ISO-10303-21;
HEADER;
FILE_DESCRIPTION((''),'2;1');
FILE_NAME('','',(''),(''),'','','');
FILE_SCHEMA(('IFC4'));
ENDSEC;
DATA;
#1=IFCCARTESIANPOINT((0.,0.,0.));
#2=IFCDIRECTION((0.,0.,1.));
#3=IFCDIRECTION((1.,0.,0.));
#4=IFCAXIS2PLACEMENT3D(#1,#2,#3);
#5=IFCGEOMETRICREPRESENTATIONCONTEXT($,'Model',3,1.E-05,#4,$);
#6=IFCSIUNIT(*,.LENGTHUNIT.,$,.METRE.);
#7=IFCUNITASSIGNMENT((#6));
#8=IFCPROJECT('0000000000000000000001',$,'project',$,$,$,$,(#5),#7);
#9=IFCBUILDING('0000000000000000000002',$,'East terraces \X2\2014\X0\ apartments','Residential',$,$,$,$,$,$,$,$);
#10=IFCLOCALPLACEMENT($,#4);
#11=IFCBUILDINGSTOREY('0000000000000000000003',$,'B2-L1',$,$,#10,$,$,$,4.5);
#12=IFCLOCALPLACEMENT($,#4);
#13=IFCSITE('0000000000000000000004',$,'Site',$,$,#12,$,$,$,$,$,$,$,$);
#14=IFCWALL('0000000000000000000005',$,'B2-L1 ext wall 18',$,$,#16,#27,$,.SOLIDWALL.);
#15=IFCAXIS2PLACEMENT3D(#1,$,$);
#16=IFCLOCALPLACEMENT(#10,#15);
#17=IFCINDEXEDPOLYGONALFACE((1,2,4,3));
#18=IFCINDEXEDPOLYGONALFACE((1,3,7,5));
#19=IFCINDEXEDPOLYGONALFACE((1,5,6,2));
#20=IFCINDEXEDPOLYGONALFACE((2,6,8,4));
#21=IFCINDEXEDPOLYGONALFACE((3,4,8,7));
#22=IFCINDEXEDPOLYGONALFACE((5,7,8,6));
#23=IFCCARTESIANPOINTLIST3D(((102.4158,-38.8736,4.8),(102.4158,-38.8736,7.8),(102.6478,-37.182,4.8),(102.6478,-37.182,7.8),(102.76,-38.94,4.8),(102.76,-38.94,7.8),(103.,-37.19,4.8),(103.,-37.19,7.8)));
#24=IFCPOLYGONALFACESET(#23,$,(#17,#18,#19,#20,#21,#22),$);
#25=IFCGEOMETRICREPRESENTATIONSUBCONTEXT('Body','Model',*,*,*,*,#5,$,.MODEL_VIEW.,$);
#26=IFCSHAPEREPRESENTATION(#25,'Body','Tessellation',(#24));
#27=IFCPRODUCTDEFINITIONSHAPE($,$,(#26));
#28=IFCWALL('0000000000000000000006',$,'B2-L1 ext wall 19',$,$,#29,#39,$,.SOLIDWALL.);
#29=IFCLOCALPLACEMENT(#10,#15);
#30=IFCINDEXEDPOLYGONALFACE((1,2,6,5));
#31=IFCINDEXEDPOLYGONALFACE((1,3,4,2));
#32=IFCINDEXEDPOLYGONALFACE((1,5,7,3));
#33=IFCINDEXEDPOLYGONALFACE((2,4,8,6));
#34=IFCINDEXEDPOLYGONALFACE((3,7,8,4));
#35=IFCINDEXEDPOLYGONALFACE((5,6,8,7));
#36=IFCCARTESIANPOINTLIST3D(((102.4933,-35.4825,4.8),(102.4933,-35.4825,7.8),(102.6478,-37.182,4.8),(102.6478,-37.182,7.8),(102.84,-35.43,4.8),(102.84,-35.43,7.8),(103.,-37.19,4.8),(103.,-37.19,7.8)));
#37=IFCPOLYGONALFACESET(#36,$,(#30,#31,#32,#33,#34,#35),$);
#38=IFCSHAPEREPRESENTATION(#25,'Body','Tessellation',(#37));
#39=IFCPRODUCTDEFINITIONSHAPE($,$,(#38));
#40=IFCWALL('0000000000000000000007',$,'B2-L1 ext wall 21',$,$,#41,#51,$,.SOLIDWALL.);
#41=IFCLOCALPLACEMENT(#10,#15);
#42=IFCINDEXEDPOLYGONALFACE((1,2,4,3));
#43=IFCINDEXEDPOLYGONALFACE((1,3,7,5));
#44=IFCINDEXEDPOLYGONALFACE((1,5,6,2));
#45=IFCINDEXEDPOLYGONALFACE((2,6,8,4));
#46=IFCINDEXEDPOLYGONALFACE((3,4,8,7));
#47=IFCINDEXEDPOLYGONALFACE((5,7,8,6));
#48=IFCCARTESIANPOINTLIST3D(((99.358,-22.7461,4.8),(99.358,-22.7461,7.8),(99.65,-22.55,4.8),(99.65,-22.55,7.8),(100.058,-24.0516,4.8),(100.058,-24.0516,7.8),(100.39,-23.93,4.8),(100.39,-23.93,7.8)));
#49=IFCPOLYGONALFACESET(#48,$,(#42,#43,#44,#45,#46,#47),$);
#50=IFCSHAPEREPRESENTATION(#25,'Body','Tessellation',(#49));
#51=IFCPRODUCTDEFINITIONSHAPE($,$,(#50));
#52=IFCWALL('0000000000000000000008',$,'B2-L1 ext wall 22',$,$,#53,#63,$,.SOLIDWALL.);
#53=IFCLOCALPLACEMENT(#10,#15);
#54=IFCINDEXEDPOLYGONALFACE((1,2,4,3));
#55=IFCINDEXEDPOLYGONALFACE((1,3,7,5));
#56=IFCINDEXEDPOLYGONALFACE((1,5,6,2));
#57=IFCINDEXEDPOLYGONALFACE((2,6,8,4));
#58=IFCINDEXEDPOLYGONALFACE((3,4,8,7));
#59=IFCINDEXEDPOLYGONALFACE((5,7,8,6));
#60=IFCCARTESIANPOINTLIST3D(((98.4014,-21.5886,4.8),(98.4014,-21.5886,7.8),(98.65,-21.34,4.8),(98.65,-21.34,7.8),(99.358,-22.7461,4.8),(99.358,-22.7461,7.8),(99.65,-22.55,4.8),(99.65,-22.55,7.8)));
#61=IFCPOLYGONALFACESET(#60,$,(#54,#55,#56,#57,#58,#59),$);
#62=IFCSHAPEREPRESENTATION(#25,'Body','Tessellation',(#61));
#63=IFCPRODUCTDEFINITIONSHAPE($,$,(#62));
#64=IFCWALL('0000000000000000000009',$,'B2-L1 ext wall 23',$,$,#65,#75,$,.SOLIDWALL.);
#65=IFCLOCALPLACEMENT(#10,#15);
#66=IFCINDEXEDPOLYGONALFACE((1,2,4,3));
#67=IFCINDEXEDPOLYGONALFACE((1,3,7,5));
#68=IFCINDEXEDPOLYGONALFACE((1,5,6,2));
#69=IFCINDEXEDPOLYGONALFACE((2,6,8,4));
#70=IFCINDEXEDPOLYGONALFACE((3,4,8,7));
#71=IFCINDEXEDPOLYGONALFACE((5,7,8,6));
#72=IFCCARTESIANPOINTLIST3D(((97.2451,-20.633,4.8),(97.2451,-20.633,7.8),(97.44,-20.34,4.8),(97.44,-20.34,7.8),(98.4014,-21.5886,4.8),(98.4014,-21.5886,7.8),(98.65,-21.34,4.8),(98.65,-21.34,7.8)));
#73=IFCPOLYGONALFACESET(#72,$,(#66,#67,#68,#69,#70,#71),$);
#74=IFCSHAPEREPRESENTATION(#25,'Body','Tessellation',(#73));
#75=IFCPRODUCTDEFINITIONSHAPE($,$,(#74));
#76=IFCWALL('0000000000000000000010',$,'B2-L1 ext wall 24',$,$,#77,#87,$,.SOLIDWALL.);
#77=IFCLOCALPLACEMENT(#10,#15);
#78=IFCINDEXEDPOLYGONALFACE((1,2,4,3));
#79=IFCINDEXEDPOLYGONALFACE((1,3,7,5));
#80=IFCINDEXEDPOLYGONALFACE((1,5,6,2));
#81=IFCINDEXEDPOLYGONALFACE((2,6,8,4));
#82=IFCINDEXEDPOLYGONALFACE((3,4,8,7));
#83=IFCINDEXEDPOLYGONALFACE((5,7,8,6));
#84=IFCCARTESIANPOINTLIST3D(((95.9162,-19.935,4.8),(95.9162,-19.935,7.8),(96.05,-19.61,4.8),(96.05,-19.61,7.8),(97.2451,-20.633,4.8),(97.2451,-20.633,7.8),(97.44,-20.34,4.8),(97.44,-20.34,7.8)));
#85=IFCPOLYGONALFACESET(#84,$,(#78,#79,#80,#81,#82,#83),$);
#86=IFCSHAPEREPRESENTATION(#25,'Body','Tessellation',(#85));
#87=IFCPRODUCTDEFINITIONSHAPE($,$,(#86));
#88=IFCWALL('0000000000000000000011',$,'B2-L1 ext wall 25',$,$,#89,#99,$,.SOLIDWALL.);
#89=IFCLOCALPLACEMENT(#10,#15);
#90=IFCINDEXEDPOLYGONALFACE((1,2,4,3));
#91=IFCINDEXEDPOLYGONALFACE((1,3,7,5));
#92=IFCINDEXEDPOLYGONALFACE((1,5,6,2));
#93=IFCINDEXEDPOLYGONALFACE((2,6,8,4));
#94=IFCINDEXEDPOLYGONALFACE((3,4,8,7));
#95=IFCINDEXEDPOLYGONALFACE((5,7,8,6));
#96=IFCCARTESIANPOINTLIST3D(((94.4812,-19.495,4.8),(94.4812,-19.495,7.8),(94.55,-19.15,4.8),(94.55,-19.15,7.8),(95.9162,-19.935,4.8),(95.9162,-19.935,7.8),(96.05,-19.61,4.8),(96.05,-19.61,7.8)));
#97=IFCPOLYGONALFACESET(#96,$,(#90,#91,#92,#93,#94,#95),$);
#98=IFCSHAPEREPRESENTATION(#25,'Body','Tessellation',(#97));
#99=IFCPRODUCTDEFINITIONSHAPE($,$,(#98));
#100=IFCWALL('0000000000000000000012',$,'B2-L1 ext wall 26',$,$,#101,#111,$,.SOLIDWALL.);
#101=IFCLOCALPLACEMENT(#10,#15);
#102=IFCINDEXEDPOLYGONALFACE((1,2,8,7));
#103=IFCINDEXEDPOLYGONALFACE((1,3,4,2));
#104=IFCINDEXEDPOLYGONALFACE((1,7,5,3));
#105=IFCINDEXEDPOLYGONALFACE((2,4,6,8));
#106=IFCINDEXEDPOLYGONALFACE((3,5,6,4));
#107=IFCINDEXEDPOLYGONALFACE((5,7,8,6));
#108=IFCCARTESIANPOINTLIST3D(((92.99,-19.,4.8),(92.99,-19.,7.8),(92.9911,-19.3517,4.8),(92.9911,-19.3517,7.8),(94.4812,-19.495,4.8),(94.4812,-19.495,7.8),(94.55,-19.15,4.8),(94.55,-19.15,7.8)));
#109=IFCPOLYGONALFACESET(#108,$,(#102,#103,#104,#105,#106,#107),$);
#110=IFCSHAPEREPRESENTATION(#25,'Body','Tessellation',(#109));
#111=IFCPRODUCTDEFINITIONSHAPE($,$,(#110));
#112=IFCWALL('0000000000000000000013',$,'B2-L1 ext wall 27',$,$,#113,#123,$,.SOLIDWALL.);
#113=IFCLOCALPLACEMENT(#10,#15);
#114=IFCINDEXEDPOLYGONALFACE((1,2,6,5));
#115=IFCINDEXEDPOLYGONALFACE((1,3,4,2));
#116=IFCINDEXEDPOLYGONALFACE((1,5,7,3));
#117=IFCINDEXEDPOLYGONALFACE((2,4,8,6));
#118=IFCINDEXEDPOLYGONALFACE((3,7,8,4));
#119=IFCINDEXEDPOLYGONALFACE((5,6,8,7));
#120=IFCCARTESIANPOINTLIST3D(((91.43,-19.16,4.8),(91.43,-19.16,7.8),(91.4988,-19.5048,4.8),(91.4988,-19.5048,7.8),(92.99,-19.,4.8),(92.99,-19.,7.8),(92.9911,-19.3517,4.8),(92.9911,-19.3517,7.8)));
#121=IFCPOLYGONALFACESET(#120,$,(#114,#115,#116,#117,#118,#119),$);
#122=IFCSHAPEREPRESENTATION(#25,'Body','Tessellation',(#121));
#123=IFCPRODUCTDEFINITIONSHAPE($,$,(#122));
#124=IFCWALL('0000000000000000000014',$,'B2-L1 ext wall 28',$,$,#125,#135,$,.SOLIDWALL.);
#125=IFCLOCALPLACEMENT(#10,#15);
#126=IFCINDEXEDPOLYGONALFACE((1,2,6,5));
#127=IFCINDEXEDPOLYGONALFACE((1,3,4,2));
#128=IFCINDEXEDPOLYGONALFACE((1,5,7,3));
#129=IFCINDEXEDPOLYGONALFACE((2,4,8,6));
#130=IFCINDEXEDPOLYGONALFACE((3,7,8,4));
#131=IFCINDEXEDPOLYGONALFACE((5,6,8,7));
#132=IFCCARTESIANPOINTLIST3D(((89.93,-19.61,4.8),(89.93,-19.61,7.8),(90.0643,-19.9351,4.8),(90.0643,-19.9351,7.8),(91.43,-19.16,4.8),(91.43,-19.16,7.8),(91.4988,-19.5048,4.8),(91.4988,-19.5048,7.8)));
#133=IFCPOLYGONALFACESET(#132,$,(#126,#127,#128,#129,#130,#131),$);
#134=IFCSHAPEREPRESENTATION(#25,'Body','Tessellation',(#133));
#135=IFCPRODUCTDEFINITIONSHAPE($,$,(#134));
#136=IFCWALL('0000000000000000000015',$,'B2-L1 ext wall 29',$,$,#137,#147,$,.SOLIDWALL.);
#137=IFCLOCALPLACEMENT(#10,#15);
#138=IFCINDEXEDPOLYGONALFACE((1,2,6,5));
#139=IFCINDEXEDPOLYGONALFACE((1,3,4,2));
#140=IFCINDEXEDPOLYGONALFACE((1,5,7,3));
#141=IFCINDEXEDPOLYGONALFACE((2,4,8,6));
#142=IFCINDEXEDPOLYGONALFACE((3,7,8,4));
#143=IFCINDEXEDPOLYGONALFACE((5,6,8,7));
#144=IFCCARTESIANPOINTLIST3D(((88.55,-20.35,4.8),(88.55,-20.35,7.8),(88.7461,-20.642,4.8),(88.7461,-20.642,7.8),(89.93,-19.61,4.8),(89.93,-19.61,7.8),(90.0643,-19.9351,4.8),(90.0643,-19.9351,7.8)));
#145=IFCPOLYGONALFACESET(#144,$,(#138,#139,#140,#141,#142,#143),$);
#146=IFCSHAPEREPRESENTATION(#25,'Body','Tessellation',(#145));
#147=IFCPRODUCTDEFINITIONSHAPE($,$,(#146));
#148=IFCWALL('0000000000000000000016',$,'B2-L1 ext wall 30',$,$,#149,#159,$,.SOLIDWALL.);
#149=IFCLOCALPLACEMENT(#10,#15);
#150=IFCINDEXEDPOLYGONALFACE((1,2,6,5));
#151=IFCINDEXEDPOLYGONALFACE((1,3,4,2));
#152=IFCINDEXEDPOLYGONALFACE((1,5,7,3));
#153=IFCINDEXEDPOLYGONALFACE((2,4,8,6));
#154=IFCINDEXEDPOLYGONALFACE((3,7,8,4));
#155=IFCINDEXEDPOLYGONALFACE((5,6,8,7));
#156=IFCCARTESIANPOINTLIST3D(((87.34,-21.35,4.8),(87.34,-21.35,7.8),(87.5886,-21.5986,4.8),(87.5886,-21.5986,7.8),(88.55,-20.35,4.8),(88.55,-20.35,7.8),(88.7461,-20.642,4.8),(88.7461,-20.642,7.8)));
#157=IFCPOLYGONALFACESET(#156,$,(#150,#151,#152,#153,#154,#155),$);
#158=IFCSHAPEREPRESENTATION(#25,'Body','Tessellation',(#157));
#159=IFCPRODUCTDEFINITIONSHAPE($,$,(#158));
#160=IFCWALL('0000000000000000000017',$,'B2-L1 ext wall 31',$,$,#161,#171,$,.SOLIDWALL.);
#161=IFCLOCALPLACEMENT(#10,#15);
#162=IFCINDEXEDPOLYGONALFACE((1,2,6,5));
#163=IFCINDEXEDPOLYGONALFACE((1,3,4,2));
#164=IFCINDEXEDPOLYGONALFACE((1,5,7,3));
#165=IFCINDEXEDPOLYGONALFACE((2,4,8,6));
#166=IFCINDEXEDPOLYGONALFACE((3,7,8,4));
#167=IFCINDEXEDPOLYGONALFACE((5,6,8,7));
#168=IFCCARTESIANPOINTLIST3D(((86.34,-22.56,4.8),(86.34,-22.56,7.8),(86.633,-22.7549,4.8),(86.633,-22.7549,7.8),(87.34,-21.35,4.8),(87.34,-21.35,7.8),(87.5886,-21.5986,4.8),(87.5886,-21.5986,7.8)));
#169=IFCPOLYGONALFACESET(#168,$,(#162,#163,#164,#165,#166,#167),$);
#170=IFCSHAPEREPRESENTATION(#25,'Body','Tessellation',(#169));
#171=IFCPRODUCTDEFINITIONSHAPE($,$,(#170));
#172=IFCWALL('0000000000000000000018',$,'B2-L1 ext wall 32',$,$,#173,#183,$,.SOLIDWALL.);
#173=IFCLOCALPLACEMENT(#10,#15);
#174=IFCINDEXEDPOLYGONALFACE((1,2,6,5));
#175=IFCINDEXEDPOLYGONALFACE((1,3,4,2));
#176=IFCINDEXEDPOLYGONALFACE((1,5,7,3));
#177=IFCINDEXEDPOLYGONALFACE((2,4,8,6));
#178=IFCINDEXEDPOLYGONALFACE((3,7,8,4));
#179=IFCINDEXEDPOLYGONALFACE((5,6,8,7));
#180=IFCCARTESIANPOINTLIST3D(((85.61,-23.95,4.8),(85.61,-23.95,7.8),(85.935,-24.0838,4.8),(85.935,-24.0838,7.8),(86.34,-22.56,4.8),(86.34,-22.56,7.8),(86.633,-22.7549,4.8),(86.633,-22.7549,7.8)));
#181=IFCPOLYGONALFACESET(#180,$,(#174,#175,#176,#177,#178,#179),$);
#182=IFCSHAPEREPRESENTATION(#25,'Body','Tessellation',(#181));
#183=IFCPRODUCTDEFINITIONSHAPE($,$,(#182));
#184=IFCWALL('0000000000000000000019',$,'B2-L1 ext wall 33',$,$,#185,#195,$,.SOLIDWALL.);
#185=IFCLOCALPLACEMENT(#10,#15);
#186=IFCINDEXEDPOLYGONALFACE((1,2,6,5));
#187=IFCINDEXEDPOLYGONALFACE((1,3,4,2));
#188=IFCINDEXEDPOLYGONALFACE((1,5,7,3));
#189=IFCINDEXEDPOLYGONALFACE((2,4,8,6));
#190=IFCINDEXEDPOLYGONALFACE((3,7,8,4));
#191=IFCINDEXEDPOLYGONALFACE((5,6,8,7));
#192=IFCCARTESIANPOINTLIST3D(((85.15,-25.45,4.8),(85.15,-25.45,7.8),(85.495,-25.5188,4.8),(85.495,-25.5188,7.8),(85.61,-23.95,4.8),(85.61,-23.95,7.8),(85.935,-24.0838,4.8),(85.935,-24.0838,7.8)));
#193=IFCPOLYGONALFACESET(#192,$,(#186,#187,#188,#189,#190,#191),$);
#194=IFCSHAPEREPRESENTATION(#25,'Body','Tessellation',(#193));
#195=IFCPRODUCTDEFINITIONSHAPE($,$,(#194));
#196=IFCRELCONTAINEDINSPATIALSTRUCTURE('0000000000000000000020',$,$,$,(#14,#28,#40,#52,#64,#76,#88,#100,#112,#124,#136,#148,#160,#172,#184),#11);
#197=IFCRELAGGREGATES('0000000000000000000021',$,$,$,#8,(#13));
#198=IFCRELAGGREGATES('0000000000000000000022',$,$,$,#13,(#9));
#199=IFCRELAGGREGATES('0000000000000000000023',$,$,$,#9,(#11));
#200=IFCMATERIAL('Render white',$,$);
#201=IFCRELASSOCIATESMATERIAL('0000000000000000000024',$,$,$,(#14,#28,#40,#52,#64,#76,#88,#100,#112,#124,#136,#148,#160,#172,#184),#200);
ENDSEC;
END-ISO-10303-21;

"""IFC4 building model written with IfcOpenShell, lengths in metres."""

from ifc_helpers import new_model, si_unit, frame, origin_with_axes, place, context, subcontext, project, spatial, polyline, outline, extrude, material, element, save


model = new_model("IFC4")

# Units and contexts
model_context = context("Model", 3, precision=1e-05, world=origin_with_axes())
body_context = subcontext(model_context, "Body", "Model", "MODEL_VIEW")
ifc_project = project(units=[si_unit("LENGTHUNIT", "METRE")], contexts=[model_context])

# Site, building, storey
site_placement = place(None, origin_with_axes())
site = spatial("IfcSite", under=ifc_project, at=site_placement, Name="Site")
building = spatial("IfcBuilding", under=site, Name="East terraces — apartments", Description="Residential")
storey_placement = place(None, origin_with_axes())
storey = spatial("IfcBuildingStorey", under=building, at=storey_placement, Name="B2-L1", Elevation=4.5)

# Walls
ifc_material_1 = material(Name="Render white")
wall_1_placement = place(storey_placement, origin_with_axes())
element("IfcWall", 1, at=wall_1_placement, inside=storey, material=ifc_material_1, Name="B2-L1 ext wall 18", PredefinedType="SOLIDWALL", context=body_context, shape_type="SweptSolid", body=[
    extrude(outline(polyline([(102.76, -38.94), (103.0, -37.19), (102.6478, -37.182), (102.4158, -38.8736), (102.76, -38.94)])), frame((0.0, 0.0, 4.8), z_axis=(0.0, 0.0, 1.0), x_axis=(1.0, 0.0, 0.0)), (0.0, 0.0, 1.0), 3.0),
])
wall_2_placement = place(storey_placement, origin_with_axes())
element("IfcWall", 2, at=wall_2_placement, inside=storey, material=ifc_material_1, Name="B2-L1 ext wall 19", PredefinedType="SOLIDWALL", context=body_context, shape_type="SweptSolid", body=[
    extrude(outline(polyline([(103.0, -37.19), (102.84, -35.43), (102.4933, -35.4825), (102.6478, -37.182), (103.0, -37.19)])), frame((0.0, 0.0, 4.8), z_axis=(0.0, 0.0, 1.0), x_axis=(1.0, 0.0, 0.0)), (0.0, 0.0, 1.0), 3.0),
])

# Walls
wall_3_placement = place(storey_placement, origin_with_axes())
element("IfcWall", 3, at=wall_3_placement, inside=storey, material=ifc_material_1, Name="B2-L1 ext wall 21", PredefinedType="SOLIDWALL", context=body_context, shape_type="SweptSolid", body=[
    extrude(outline(polyline([(100.39, -23.93), (99.65, -22.55), (99.358, -22.7461), (100.058, -24.0516), (100.39, -23.93)])), frame((0.0, 0.0, 4.8), z_axis=(0.0, 0.0, 1.0), x_axis=(1.0, 0.0, 0.0)), (0.0, 0.0, 1.0), 3.0),
])
wall_4_placement = place(storey_placement, origin_with_axes())
element("IfcWall", 4, at=wall_4_placement, inside=storey, material=ifc_material_1, Name="B2-L1 ext wall 22", PredefinedType="SOLIDWALL", context=body_context, shape_type="SweptSolid", body=[
    extrude(outline(polyline([(99.65, -22.55), (98.65, -21.34), (98.4014, -21.5886), (99.358, -22.7461), (99.65, -22.55)])), frame((0.0, 0.0, 4.8), z_axis=(0.0, 0.0, 1.0), x_axis=(1.0, 0.0, 0.0)), (0.0, 0.0, 1.0), 3.0),
])
wall_5_placement = place(storey_placement, origin_with_axes())
element("IfcWall", 5, at=wall_5_placement, inside=storey, material=ifc_material_1, Name="B2-L1 ext wall 23", PredefinedType="SOLIDWALL", context=body_context, shape_type="SweptSolid", body=[
    extrude(outline(polyline([(98.65, -21.34), (97.44, -20.34), (97.2451, -20.633), (98.4014, -21.5886), (98.65, -21.34)])), frame((0.0, 0.0, 4.8), z_axis=(0.0, 0.0, 1.0), x_axis=(1.0, 0.0, 0.0)), (0.0, 0.0, 1.0), 3.0),
])
wall_6_placement = place(storey_placement, origin_with_axes())
element("IfcWall", 6, at=wall_6_placement, inside=storey, material=ifc_material_1, Name="B2-L1 ext wall 24", PredefinedType="SOLIDWALL", context=body_context, shape_type="SweptSolid", body=[
    extrude(outline(polyline([(97.44, -20.34), (96.05, -19.61), (95.9162, -19.935), (97.2451, -20.633), (97.44, -20.34)])), frame((0.0, 0.0, 4.8), z_axis=(0.0, 0.0, 1.0), x_axis=(1.0, 0.0, 0.0)), (0.0, 0.0, 1.0), 3.0),
])
wall_7_placement = place(storey_placement, origin_with_axes())
element("IfcWall", 7, at=wall_7_placement, inside=storey, material=ifc_material_1, Name="B2-L1 ext wall 25", PredefinedType="SOLIDWALL", context=body_context, shape_type="SweptSolid", body=[
    extrude(outline(polyline([(96.05, -19.61), (94.55, -19.15), (94.4812, -19.495), (95.9162, -19.935), (96.05, -19.61)])), frame((0.0, 0.0, 4.8), z_axis=(0.0, 0.0, 1.0), x_axis=(1.0, 0.0, 0.0)), (0.0, 0.0, 1.0), 3.0),
])
wall_8_placement = place(storey_placement, origin_with_axes())
element("IfcWall", 8, at=wall_8_placement, inside=storey, material=ifc_material_1, Name="B2-L1 ext wall 26", PredefinedType="SOLIDWALL", context=body_context, shape_type="SweptSolid", body=[
    extrude(outline(polyline([(94.55, -19.15), (92.99, -19.0), (92.9911, -19.3517), (94.4812, -19.495), (94.55, -19.15)])), frame((0.0, 0.0, 4.8), z_axis=(0.0, 0.0, 1.0), x_axis=(1.0, 0.0, 0.0)), (0.0, 0.0, 1.0), 3.0),
])
wall_9_placement = place(storey_placement, origin_with_axes())
element("IfcWall", 9, at=wall_9_placement, inside=storey, material=ifc_material_1, Name="B2-L1 ext wall 27", PredefinedType="SOLIDWALL", context=body_context, shape_type="SweptSolid", body=[
    extrude(outline(polyline([(92.99, -19.0), (91.43, -19.16), (91.4988, -19.5048), (92.9911, -19.3517), (92.99, -19.0)])), frame((0.0, 0.0, 4.8), z_axis=(0.0, 0.0, 1.0), x_axis=(1.0, 0.0, 0.0)), (0.0, 0.0, 1.0), 3.0),
])
wall_10_placement = place(storey_placement, origin_with_axes())
element("IfcWall", 10, at=wall_10_placement, inside=storey, material=ifc_material_1, Name="B2-L1 ext wall 28", PredefinedType="SOLIDWALL", context=body_context, shape_type="SweptSolid", body=[
    extrude(outline(polyline([(91.43, -19.16), (89.93, -19.61), (90.0643, -19.9351), (91.4988, -19.5048), (91.43, -19.16)])), frame((0.0, 0.0, 4.8), z_axis=(0.0, 0.0, 1.0), x_axis=(1.0, 0.0, 0.0)), (0.0, 0.0, 1.0), 3.0),
])
wall_11_placement = place(storey_placement, origin_with_axes())
element("IfcWall", 11, at=wall_11_placement, inside=storey, material=ifc_material_1, Name="B2-L1 ext wall 29", PredefinedType="SOLIDWALL", context=body_context, shape_type="SweptSolid", body=[
    extrude(outline(polyline([(89.93, -19.61), (88.55, -20.35), (88.7461, -20.642), (90.0643, -19.9351), (89.93, -19.61)])), frame((0.0, 0.0, 4.8), z_axis=(0.0, 0.0, 1.0), x_axis=(1.0, 0.0, 0.0)), (0.0, 0.0, 1.0), 3.0),
])
wall_12_placement = place(storey_placement, origin_with_axes())
element("IfcWall", 12, at=wall_12_placement, inside=storey, material=ifc_material_1, Name="B2-L1 ext wall 30", PredefinedType="SOLIDWALL", context=body_context, shape_type="SweptSolid", body=[
    extrude(outline(polyline([(88.55, -20.35), (87.34, -21.35), (87.5886, -21.5986), (88.7461, -20.642), (88.55, -20.35)])), frame((0.0, 0.0, 4.8), z_axis=(0.0, 0.0, 1.0), x_axis=(1.0, 0.0, 0.0)), (0.0, 0.0, 1.0), 3.0),
])
wall_13_placement = place(storey_placement, origin_with_axes())
element("IfcWall", 13, at=wall_13_placement, inside=storey, material=ifc_material_1, Name="B2-L1 ext wall 31", PredefinedType="SOLIDWALL", context=body_context, shape_type="SweptSolid", body=[
    extrude(outline(polyline([(87.34, -21.35), (86.34, -22.56), (86.633, -22.7549), (87.5886, -21.5986), (87.34, -21.35)])), frame((0.0, 0.0, 4.8), z_axis=(0.0, 0.0, 1.0), x_axis=(1.0, 0.0, 0.0)), (0.0, 0.0, 1.0), 3.0),
])
wall_14_placement = place(storey_placement, origin_with_axes())
element("IfcWall", 14, at=wall_14_placement, inside=storey, material=ifc_material_1, Name="B2-L1 ext wall 32", PredefinedType="SOLIDWALL", context=body_context, shape_type="SweptSolid", body=[
    extrude(outline(polyline([(86.34, -22.56), (85.61, -23.95), (85.935, -24.0838), (86.633, -22.7549), (86.34, -22.56)])), frame((0.0, 0.0, 4.8), z_axis=(0.0, 0.0, 1.0), x_axis=(1.0, 0.0, 0.0)), (0.0, 0.0, 1.0), 3.0),
])
wall_15_placement = place(storey_placement, origin_with_axes())
element("IfcWall", 15, at=wall_15_placement, inside=storey, material=ifc_material_1, Name="B2-L1 ext wall 33", PredefinedType="SOLIDWALL", context=body_context, shape_type="SweptSolid", body=[
    extrude(outline(polyline([(85.61, -23.95), (85.15, -25.45), (85.495, -25.5188), (85.935, -24.0838), (85.61, -23.95)])), frame((0.0, 0.0, 4.8), z_axis=(0.0, 0.0, 1.0), x_axis=(1.0, 0.0, 0.0)), (0.0, 0.0, 1.0), 3.0),
])

save(model, "model.ifc")
